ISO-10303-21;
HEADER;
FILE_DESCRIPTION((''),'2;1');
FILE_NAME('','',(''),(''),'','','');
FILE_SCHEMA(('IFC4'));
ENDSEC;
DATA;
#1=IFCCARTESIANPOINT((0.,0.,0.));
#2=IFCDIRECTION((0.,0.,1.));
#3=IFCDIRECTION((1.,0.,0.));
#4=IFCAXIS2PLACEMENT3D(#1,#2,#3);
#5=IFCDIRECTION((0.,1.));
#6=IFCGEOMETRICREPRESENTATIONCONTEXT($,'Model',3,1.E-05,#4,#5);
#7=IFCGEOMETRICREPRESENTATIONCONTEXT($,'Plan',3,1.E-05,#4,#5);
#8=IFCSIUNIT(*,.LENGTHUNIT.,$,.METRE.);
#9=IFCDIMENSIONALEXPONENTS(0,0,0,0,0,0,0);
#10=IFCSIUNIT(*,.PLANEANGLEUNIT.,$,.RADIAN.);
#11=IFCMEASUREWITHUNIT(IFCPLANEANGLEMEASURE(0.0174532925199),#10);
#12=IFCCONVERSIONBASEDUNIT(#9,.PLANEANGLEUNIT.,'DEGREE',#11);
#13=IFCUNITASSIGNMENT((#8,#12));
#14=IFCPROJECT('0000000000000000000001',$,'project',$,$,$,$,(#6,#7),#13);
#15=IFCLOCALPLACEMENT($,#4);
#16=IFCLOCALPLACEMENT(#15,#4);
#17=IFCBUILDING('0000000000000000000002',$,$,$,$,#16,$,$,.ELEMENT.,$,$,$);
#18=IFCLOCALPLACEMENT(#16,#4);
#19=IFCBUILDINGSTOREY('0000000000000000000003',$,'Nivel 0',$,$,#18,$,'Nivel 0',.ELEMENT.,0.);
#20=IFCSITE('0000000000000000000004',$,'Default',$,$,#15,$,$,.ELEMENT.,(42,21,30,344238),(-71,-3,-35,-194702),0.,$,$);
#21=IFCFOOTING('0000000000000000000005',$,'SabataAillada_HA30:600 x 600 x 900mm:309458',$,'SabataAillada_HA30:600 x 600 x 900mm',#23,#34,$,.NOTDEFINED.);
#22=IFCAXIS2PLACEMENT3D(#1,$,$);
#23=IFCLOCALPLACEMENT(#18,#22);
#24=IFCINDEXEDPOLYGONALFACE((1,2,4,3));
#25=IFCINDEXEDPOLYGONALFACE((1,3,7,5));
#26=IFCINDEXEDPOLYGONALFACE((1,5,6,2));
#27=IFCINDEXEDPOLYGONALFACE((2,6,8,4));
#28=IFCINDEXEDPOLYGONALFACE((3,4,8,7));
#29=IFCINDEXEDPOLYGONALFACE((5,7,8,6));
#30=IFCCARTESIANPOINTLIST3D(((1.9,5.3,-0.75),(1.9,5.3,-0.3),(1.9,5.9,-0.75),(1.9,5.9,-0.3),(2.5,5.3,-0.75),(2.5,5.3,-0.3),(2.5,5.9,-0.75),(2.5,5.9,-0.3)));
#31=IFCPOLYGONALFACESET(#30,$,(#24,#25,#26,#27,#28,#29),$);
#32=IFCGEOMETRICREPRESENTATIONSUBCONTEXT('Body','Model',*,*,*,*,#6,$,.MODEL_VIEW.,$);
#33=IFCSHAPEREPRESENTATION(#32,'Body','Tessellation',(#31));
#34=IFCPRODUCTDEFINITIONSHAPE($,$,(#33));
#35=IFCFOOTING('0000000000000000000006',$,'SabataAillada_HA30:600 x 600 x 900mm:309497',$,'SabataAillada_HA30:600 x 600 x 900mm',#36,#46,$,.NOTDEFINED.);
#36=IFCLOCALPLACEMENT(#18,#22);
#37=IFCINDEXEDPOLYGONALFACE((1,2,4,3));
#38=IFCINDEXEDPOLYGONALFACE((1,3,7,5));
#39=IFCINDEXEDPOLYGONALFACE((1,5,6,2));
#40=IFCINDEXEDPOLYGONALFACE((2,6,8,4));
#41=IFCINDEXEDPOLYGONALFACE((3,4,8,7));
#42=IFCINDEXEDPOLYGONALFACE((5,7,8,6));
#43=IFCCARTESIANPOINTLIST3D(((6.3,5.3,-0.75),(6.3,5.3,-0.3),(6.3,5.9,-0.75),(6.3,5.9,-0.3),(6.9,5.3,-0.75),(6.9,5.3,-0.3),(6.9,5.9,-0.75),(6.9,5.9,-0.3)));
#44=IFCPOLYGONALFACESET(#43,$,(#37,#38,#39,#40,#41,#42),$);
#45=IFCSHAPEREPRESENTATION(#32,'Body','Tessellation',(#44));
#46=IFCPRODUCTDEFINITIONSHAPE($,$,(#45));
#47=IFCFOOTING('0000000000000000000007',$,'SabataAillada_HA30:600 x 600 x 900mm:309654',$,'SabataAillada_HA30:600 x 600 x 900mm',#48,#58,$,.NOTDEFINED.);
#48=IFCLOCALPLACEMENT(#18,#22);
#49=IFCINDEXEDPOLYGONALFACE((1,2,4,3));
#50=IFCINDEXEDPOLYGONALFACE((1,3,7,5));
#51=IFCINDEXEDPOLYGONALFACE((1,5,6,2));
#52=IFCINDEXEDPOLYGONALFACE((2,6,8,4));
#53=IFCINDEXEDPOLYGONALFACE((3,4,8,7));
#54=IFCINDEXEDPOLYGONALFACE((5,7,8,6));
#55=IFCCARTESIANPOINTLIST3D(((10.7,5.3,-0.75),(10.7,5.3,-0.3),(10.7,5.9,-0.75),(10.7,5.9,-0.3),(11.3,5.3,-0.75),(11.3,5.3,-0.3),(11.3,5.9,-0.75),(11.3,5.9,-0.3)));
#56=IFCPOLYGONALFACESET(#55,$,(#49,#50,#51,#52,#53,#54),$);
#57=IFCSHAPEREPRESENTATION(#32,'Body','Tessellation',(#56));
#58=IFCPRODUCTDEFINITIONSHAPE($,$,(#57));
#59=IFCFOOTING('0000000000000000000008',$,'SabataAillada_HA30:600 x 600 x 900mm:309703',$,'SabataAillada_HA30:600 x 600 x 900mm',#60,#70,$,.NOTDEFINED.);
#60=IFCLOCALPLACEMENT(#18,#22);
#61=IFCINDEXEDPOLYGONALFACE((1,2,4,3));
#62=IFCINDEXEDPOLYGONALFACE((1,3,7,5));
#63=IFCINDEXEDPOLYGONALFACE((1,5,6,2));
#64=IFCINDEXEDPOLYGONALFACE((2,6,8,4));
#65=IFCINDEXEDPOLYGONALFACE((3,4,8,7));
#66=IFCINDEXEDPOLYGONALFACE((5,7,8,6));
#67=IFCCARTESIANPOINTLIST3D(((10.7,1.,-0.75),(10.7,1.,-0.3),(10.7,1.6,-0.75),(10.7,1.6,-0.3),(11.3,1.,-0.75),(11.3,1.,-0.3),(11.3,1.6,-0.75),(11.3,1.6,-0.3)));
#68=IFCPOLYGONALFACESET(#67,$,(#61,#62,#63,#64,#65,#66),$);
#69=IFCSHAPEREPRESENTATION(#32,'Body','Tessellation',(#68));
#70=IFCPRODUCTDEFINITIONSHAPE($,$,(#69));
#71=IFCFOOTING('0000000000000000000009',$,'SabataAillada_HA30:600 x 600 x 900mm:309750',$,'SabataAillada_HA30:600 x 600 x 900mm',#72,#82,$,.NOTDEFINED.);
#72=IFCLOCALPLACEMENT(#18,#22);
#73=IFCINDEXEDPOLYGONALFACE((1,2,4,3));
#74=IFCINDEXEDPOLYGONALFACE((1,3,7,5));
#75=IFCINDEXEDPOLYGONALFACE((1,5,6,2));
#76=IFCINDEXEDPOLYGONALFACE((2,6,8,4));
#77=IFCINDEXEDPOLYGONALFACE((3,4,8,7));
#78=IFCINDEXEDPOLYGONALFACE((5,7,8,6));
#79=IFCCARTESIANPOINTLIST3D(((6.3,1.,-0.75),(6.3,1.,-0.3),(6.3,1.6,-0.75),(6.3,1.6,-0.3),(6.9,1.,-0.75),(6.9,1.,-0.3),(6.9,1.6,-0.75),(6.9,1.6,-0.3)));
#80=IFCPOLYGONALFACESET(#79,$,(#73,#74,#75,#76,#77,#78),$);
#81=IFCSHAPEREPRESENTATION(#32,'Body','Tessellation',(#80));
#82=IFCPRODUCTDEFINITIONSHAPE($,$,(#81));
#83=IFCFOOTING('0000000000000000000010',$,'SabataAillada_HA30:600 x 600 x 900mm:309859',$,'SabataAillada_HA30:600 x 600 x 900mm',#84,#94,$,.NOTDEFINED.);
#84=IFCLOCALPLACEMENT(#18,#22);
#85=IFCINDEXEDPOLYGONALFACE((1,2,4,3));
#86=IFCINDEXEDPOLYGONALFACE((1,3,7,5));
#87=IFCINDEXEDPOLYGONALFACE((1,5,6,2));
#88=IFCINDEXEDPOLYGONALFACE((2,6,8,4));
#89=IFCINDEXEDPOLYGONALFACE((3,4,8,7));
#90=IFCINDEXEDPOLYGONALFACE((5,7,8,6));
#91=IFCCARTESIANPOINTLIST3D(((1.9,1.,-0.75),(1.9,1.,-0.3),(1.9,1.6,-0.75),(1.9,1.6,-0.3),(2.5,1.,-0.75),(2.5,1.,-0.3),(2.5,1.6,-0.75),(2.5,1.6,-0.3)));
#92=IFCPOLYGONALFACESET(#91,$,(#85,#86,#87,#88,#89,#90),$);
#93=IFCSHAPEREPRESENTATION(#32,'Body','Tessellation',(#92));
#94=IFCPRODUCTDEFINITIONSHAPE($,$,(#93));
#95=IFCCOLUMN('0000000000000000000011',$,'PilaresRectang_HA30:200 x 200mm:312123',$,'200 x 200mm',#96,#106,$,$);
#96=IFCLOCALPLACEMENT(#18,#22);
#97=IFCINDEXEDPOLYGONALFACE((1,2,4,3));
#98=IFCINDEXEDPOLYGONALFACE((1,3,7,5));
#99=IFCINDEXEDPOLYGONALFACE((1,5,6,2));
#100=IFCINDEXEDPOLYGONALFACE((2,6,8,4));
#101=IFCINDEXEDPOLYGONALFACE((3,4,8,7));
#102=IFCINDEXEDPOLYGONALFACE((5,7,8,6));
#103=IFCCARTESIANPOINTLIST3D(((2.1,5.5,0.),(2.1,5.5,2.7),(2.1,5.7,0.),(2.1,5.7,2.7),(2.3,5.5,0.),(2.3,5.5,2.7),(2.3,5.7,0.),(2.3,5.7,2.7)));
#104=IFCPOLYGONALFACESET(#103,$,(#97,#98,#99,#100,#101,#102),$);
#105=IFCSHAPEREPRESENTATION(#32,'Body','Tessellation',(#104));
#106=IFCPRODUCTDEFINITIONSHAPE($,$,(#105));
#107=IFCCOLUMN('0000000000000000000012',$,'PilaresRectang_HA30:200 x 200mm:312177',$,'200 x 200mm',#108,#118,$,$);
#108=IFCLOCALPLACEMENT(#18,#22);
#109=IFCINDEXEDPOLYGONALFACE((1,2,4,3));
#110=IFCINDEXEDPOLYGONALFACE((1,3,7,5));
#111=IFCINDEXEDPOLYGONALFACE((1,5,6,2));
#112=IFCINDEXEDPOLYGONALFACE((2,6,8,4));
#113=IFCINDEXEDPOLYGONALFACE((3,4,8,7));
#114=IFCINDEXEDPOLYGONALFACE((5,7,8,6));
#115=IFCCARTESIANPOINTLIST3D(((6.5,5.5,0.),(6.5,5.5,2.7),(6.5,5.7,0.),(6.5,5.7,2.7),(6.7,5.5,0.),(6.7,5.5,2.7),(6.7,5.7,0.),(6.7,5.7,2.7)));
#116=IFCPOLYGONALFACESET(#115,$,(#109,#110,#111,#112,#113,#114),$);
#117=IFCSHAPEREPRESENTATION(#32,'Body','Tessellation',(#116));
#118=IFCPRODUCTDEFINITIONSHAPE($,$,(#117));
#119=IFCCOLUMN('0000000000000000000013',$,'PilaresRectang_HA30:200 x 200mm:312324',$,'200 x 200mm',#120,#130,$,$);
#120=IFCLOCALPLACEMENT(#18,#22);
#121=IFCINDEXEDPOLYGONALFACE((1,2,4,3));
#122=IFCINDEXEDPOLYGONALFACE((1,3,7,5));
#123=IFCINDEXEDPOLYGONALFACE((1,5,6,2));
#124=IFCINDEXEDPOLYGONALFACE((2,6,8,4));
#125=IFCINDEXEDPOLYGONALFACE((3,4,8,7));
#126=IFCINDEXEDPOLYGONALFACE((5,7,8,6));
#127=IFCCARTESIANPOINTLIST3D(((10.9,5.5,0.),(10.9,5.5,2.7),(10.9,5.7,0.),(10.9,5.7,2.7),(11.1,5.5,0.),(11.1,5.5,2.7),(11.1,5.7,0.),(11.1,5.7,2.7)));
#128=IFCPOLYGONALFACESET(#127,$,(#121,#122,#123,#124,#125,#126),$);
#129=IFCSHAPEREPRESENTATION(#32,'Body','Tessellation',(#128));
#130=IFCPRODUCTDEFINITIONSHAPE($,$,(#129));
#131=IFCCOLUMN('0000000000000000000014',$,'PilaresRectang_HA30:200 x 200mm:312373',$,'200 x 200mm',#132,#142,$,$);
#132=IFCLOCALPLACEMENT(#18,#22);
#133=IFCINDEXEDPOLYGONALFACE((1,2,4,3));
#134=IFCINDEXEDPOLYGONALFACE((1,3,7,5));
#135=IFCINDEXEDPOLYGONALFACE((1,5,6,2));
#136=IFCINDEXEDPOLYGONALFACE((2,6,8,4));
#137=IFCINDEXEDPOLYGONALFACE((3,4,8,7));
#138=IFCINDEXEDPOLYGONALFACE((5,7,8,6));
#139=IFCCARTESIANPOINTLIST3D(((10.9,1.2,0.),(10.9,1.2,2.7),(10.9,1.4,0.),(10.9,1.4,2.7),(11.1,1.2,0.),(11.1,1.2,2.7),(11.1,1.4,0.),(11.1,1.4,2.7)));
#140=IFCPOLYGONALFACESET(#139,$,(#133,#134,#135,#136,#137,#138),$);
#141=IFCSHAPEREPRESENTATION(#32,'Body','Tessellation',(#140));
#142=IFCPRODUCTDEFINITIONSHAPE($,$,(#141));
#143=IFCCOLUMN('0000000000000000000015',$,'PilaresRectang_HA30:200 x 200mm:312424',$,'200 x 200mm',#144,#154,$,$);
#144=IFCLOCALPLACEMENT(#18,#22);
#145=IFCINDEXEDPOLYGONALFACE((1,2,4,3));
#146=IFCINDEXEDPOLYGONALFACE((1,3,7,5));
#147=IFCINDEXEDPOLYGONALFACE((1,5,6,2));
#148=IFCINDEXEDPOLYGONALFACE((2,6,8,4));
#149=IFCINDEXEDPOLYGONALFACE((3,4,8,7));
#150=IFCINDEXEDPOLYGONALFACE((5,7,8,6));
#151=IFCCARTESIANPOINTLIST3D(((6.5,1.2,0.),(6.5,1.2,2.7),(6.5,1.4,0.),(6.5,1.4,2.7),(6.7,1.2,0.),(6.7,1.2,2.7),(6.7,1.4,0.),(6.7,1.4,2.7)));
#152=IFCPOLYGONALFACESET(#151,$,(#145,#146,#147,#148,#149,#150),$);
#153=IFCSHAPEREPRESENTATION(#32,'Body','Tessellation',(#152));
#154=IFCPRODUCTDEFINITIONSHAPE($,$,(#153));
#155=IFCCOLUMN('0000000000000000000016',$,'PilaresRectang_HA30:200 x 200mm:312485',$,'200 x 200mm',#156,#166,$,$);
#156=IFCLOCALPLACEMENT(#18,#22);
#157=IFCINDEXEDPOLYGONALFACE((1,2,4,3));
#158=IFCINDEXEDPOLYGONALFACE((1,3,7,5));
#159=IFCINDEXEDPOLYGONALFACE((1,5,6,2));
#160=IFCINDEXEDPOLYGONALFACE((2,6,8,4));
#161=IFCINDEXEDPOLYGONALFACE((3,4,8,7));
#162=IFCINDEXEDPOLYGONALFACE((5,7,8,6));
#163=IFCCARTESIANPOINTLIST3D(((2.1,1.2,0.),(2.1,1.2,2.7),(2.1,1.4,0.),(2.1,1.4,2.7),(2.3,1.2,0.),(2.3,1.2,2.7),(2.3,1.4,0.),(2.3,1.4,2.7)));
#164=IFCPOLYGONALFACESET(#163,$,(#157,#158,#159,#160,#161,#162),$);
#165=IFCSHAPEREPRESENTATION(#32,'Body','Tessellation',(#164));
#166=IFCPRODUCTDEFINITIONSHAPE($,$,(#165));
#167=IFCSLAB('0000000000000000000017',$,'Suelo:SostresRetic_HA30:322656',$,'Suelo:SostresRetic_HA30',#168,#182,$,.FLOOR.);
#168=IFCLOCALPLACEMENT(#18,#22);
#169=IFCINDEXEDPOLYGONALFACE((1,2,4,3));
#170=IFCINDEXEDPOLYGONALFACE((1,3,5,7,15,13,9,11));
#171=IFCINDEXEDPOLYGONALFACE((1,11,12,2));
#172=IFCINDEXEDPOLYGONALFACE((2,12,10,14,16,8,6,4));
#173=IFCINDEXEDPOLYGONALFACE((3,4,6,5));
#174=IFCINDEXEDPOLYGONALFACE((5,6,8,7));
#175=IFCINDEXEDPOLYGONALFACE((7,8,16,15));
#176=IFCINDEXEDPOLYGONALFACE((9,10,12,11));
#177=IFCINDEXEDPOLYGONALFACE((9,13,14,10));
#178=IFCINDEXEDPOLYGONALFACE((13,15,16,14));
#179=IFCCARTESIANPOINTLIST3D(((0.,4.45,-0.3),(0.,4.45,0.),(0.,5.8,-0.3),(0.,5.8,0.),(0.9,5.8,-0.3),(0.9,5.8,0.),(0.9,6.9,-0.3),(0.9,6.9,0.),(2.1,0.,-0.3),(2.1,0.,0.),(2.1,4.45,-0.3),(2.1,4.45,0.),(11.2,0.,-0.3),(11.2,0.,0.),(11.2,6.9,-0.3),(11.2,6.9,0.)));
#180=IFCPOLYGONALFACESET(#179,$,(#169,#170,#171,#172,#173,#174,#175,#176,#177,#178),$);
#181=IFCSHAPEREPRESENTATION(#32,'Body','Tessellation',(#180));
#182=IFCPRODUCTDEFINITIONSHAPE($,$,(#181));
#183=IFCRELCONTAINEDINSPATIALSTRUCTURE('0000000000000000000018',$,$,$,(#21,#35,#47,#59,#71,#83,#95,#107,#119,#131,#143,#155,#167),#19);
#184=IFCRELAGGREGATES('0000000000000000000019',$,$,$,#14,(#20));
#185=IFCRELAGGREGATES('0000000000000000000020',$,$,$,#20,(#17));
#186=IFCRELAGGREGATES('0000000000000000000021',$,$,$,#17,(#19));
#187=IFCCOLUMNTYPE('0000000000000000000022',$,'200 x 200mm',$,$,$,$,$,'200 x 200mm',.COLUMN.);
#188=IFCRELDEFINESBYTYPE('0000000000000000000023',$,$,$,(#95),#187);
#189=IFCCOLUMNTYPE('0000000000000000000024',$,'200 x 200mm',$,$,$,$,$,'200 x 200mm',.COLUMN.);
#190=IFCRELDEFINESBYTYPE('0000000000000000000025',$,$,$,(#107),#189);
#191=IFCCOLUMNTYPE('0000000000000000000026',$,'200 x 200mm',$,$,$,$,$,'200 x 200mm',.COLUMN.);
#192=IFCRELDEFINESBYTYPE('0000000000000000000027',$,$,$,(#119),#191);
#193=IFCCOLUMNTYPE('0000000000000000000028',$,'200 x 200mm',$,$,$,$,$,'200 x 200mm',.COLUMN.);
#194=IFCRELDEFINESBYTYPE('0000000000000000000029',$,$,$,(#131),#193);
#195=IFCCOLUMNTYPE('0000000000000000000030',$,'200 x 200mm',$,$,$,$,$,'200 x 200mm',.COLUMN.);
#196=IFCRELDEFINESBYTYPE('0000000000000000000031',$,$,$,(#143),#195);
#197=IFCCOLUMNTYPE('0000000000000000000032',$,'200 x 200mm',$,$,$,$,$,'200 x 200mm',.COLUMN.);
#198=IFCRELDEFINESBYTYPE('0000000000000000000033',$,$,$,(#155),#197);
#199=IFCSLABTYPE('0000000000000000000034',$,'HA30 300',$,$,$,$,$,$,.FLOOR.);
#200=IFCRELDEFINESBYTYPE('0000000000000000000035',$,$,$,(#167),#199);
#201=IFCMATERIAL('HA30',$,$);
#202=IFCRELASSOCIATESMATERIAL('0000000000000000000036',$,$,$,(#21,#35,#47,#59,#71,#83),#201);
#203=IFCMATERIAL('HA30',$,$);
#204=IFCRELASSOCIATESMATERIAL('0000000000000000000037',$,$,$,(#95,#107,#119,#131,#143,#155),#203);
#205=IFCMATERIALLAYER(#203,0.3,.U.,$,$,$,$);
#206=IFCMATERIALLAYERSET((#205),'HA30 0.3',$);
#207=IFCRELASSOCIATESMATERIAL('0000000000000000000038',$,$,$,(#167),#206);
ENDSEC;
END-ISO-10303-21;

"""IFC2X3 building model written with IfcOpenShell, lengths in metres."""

from ifc_helpers import new_model, entity, si_unit, converted_unit, direction, frame, origin_with_axes, origin_2d_with_axis, place, context, subcontext, project, spatial, polyline, rectangle, outline, extrude, material, layer, layer_set, layer_usage, type_object, element, save


model = new_model("IFC2X3")

# Units and contexts
model_context = context("Model", 3, precision=1e-05, world=origin_with_axes(), true_north=direction((0.0, 1.0)))
plan_context = context("Plan", 3, precision=1e-05, world=origin_with_axes(), true_north=direction((0.0, 1.0)))
body_context = subcontext(model_context, "Body", "Model", "MODEL_VIEW")
ifc_project = project(units=[si_unit("LENGTHUNIT", "METRE"), converted_unit("PLANEANGLEUNIT", "DEGREE", entity("IfcPlaneAngleMeasure", 0.0174532925199), si_unit("PLANEANGLEUNIT", "RADIAN"), dimensions=[0, 0, 0, 0, 0, 0, 0])], contexts=[model_context, plan_context])

# Site, building, storey
site_placement = place(None, origin_with_axes())
site = spatial("IfcSite", under=ifc_project, at=site_placement, Name="Default", CompositionType="ELEMENT", RefLatitude=(42, 21, 30, 344238), RefLongitude=(-71, -3, -35, -194702), RefElevation=0.0)
building_placement = place(site_placement, origin_with_axes())
building = spatial("IfcBuilding", under=site, at=building_placement, CompositionType="ELEMENT")
storey_placement = place(building_placement, origin_with_axes())
storey = spatial("IfcBuildingStorey", under=building, at=storey_placement, Name="Nivel 0", LongName="Nivel 0", CompositionType="ELEMENT", Elevation=0.0)

# Footings
ifc_material_1 = material(Name="HA30")
footing_1_placement = place(storey_placement, origin_with_axes())
element("IfcFooting", 1, at=footing_1_placement, inside=storey, material=ifc_material_1, Name="SabataAillada_HA30:600 x 600 x 900mm:309458", ObjectType="SabataAillada_HA30:600 x 600 x 900mm", PredefinedType="NOTDEFINED", context=body_context, shape_type="SweptSolid", body=[
    extrude(rectangle(XDim=0.6, YDim=0.6, at=origin_2d_with_axis()), frame((2.2, 5.6, -0.75), z_axis=(0.0, 0.0, 1.0), x_axis=(-1.0, 0.0, 0.0)), (0.0, 0.0, 1.0), 0.45),
])
footing_2_placement = place(storey_placement, origin_with_axes())
element("IfcFooting", 2, at=footing_2_placement, inside=storey, material=ifc_material_1, Name="SabataAillada_HA30:600 x 600 x 900mm:309497", ObjectType="SabataAillada_HA30:600 x 600 x 900mm", PredefinedType="NOTDEFINED", context=body_context, shape_type="SweptSolid", body=[
    extrude(rectangle(XDim=0.6, YDim=0.6, at=origin_2d_with_axis()), frame((6.6, 5.6, -0.75), z_axis=(0.0, 0.0, 1.0), x_axis=(-1.0, 0.0, 0.0)), (0.0, 0.0, 1.0), 0.45),
])
footing_3_placement = place(storey_placement, origin_with_axes())
element("IfcFooting", 3, at=footing_3_placement, inside=storey, material=ifc_material_1, Name="SabataAillada_HA30:600 x 600 x 900mm:309654", ObjectType="SabataAillada_HA30:600 x 600 x 900mm", PredefinedType="NOTDEFINED", context=body_context, shape_type="SweptSolid", body=[
    extrude(rectangle(XDim=0.6, YDim=0.6, at=origin_2d_with_axis()), frame((11.0, 5.6, -0.75), z_axis=(0.0, 0.0, 1.0), x_axis=(-1.0, 0.0, 0.0)), (0.0, 0.0, 1.0), 0.45),
])
footing_4_placement = place(storey_placement, origin_with_axes())
element("IfcFooting", 4, at=footing_4_placement, inside=storey, material=ifc_material_1, Name="SabataAillada_HA30:600 x 600 x 900mm:309703", ObjectType="SabataAillada_HA30:600 x 600 x 900mm", PredefinedType="NOTDEFINED", context=body_context, shape_type="SweptSolid", body=[
    extrude(rectangle(XDim=0.6, YDim=0.6, at=origin_2d_with_axis()), frame((11.0, 1.3, -0.75), z_axis=(0.0, 0.0, 1.0), x_axis=(-1.0, 0.0, 0.0)), (0.0, 0.0, 1.0), 0.45),
])
footing_5_placement = place(storey_placement, origin_with_axes())
element("IfcFooting", 5, at=footing_5_placement, inside=storey, material=ifc_material_1, Name="SabataAillada_HA30:600 x 600 x 900mm:309750", ObjectType="SabataAillada_HA30:600 x 600 x 900mm", PredefinedType="NOTDEFINED", context=body_context, shape_type="SweptSolid", body=[
    extrude(rectangle(XDim=0.6, YDim=0.6, at=origin_2d_with_axis()), frame((6.6, 1.3, -0.75), z_axis=(0.0, 0.0, 1.0), x_axis=(-1.0, 0.0, 0.0)), (0.0, 0.0, 1.0), 0.45),
])
footing_6_placement = place(storey_placement, origin_with_axes())
element("IfcFooting", 6, at=footing_6_placement, inside=storey, material=ifc_material_1, Name="SabataAillada_HA30:600 x 600 x 900mm:309859", ObjectType="SabataAillada_HA30:600 x 600 x 900mm", PredefinedType="NOTDEFINED", context=body_context, shape_type="SweptSolid", body=[
    extrude(rectangle(XDim=0.6, YDim=0.6, at=origin_2d_with_axis()), frame((2.2, 1.3, -0.75), z_axis=(0.0, 0.0, 1.0), x_axis=(-1.0, 0.0, 0.0)), (0.0, 0.0, 1.0), 0.45),
])

# Columns
ifc_material_2 = material(Name="HA30")
column_type_1 = type_object("IfcColumnType", Name="200 x 200mm", ElementType="200 x 200mm", PredefinedType="COLUMN")
column_1_placement = place(storey_placement, frame((2.2, 5.6, 0.0), z_axis=(0.0, 0.0, 1.0), x_axis=(0.0, -1.0, 0.0)))
element("IfcColumn", 7, at=column_1_placement, inside=storey, type_object=column_type_1, material=ifc_material_2, Name="PilaresRectang_HA30:200 x 200mm:312123", ObjectType="200 x 200mm", context=body_context, shape_type="SweptSolid", body=[
    extrude(rectangle(XDim=0.2, YDim=0.2, at=origin_2d_with_axis()), origin_with_axes(), (0.0, 0.0, 1.0), 2.7),
])
column_type_2 = type_object("IfcColumnType", Name="200 x 200mm", ElementType="200 x 200mm", PredefinedType="COLUMN")
column_2_placement = place(storey_placement, frame((6.6, 5.6, 0.0), z_axis=(0.0, 0.0, 1.0), x_axis=(0.0, -1.0, 0.0)))
element("IfcColumn", 8, at=column_2_placement, inside=storey, type_object=column_type_2, material=ifc_material_2, Name="PilaresRectang_HA30:200 x 200mm:312177", ObjectType="200 x 200mm", context=body_context, shape_type="SweptSolid", body=[
    extrude(rectangle(XDim=0.2, YDim=0.2, at=origin_2d_with_axis()), origin_with_axes(), (0.0, 0.0, 1.0), 2.7),
])
column_type_3 = type_object("IfcColumnType", Name="200 x 200mm", ElementType="200 x 200mm", PredefinedType="COLUMN")
column_3_placement = place(storey_placement, frame((11.0, 5.6, 0.0), z_axis=(0.0, 0.0, 1.0), x_axis=(0.0, -1.0, 0.0)))
element("IfcColumn", 9, at=column_3_placement, inside=storey, type_object=column_type_3, material=ifc_material_2, Name="PilaresRectang_HA30:200 x 200mm:312324", ObjectType="200 x 200mm", context=body_context, shape_type="SweptSolid", body=[
    extrude(rectangle(XDim=0.2, YDim=0.2, at=origin_2d_with_axis()), origin_with_axes(), (0.0, 0.0, 1.0), 2.7),
])
column_type_4 = type_object("IfcColumnType", Name="200 x 200mm", ElementType="200 x 200mm", PredefinedType="COLUMN")
column_4_placement = place(storey_placement, frame((11.0, 1.3, 0.0), z_axis=(0.0, 0.0, 1.0), x_axis=(0.0, -1.0, 0.0)))
element("IfcColumn", 10, at=column_4_placement, inside=storey, type_object=column_type_4, material=ifc_material_2, Name="PilaresRectang_HA30:200 x 200mm:312373", ObjectType="200 x 200mm", context=body_context, shape_type="SweptSolid", body=[
    extrude(rectangle(XDim=0.2, YDim=0.2, at=origin_2d_with_axis()), origin_with_axes(), (0.0, 0.0, 1.0), 2.7),
])
column_type_5 = type_object("IfcColumnType", Name="200 x 200mm", ElementType="200 x 200mm", PredefinedType="COLUMN")
column_5_placement = place(storey_placement, frame((6.6, 1.3, 0.0), z_axis=(0.0, 0.0, 1.0), x_axis=(0.0, -1.0, 0.0)))
element("IfcColumn", 11, at=column_5_placement, inside=storey, type_object=column_type_5, material=ifc_material_2, Name="PilaresRectang_HA30:200 x 200mm:312424", ObjectType="200 x 200mm", context=body_context, shape_type="SweptSolid", body=[
    extrude(rectangle(XDim=0.2, YDim=0.2, at=origin_2d_with_axis()), origin_with_axes(), (0.0, 0.0, 1.0), 2.7),
])
column_type_6 = type_object("IfcColumnType", Name="200 x 200mm", ElementType="200 x 200mm", PredefinedType="COLUMN")
column_6_placement = place(storey_placement, frame((2.2, 1.3, 0.0), z_axis=(0.0, 0.0, 1.0), x_axis=(0.0, -1.0, 0.0)))
element("IfcColumn", 12, at=column_6_placement, inside=storey, type_object=column_type_6, material=ifc_material_2, Name="PilaresRectang_HA30:200 x 200mm:312485", ObjectType="200 x 200mm", context=body_context, shape_type="SweptSolid", body=[
    extrude(rectangle(XDim=0.2, YDim=0.2, at=origin_2d_with_axis()), origin_with_axes(), (0.0, 0.0, 1.0), 2.7),
])

# Slab
ifc_layer = layer(ifc_material_2, 0.3, ventilated="UNKNOWN")
ifc_layer_set = layer_set([ifc_layer], Name="HA30 0.3")
ifc_layer_usage = layer_usage(ifc_layer_set, "AXIS3", "NEGATIVE", 0.3)
slab_type = type_object("IfcSlabType", Name="HA30 300", PredefinedType="FLOOR")
slab_placement = place(storey_placement, frame((0.0, 4.45, 0.0), z_axis=(0.0, 0.0, 1.0), x_axis=(1.0, 0.0, 0.0)))
element("IfcSlab", 13, at=slab_placement, inside=storey, type_object=slab_type, material=ifc_layer_usage, Name="Suelo:SostresRetic_HA30:322656", ObjectType="Suelo:SostresRetic_HA30", PredefinedType="FLOOR", context=body_context, shape_type="SweptSolid", body=[
    extrude(outline(polyline([(0.0, 0.0), (2.1, 0.0), (2.1, -4.45), (11.2, -4.45), (11.2, 2.45), (0.9, 2.45), (0.9, 1.35), (0.0, 1.35), (0.0, 0.0)])), frame((0.0, 0.0, -0.3), z_axis=(0.0, 0.0, 1.0), x_axis=(1.0, 0.0, 0.0)), (0.0, 0.0, 1.0), 0.3),
])

save(model, "model.ifc")
